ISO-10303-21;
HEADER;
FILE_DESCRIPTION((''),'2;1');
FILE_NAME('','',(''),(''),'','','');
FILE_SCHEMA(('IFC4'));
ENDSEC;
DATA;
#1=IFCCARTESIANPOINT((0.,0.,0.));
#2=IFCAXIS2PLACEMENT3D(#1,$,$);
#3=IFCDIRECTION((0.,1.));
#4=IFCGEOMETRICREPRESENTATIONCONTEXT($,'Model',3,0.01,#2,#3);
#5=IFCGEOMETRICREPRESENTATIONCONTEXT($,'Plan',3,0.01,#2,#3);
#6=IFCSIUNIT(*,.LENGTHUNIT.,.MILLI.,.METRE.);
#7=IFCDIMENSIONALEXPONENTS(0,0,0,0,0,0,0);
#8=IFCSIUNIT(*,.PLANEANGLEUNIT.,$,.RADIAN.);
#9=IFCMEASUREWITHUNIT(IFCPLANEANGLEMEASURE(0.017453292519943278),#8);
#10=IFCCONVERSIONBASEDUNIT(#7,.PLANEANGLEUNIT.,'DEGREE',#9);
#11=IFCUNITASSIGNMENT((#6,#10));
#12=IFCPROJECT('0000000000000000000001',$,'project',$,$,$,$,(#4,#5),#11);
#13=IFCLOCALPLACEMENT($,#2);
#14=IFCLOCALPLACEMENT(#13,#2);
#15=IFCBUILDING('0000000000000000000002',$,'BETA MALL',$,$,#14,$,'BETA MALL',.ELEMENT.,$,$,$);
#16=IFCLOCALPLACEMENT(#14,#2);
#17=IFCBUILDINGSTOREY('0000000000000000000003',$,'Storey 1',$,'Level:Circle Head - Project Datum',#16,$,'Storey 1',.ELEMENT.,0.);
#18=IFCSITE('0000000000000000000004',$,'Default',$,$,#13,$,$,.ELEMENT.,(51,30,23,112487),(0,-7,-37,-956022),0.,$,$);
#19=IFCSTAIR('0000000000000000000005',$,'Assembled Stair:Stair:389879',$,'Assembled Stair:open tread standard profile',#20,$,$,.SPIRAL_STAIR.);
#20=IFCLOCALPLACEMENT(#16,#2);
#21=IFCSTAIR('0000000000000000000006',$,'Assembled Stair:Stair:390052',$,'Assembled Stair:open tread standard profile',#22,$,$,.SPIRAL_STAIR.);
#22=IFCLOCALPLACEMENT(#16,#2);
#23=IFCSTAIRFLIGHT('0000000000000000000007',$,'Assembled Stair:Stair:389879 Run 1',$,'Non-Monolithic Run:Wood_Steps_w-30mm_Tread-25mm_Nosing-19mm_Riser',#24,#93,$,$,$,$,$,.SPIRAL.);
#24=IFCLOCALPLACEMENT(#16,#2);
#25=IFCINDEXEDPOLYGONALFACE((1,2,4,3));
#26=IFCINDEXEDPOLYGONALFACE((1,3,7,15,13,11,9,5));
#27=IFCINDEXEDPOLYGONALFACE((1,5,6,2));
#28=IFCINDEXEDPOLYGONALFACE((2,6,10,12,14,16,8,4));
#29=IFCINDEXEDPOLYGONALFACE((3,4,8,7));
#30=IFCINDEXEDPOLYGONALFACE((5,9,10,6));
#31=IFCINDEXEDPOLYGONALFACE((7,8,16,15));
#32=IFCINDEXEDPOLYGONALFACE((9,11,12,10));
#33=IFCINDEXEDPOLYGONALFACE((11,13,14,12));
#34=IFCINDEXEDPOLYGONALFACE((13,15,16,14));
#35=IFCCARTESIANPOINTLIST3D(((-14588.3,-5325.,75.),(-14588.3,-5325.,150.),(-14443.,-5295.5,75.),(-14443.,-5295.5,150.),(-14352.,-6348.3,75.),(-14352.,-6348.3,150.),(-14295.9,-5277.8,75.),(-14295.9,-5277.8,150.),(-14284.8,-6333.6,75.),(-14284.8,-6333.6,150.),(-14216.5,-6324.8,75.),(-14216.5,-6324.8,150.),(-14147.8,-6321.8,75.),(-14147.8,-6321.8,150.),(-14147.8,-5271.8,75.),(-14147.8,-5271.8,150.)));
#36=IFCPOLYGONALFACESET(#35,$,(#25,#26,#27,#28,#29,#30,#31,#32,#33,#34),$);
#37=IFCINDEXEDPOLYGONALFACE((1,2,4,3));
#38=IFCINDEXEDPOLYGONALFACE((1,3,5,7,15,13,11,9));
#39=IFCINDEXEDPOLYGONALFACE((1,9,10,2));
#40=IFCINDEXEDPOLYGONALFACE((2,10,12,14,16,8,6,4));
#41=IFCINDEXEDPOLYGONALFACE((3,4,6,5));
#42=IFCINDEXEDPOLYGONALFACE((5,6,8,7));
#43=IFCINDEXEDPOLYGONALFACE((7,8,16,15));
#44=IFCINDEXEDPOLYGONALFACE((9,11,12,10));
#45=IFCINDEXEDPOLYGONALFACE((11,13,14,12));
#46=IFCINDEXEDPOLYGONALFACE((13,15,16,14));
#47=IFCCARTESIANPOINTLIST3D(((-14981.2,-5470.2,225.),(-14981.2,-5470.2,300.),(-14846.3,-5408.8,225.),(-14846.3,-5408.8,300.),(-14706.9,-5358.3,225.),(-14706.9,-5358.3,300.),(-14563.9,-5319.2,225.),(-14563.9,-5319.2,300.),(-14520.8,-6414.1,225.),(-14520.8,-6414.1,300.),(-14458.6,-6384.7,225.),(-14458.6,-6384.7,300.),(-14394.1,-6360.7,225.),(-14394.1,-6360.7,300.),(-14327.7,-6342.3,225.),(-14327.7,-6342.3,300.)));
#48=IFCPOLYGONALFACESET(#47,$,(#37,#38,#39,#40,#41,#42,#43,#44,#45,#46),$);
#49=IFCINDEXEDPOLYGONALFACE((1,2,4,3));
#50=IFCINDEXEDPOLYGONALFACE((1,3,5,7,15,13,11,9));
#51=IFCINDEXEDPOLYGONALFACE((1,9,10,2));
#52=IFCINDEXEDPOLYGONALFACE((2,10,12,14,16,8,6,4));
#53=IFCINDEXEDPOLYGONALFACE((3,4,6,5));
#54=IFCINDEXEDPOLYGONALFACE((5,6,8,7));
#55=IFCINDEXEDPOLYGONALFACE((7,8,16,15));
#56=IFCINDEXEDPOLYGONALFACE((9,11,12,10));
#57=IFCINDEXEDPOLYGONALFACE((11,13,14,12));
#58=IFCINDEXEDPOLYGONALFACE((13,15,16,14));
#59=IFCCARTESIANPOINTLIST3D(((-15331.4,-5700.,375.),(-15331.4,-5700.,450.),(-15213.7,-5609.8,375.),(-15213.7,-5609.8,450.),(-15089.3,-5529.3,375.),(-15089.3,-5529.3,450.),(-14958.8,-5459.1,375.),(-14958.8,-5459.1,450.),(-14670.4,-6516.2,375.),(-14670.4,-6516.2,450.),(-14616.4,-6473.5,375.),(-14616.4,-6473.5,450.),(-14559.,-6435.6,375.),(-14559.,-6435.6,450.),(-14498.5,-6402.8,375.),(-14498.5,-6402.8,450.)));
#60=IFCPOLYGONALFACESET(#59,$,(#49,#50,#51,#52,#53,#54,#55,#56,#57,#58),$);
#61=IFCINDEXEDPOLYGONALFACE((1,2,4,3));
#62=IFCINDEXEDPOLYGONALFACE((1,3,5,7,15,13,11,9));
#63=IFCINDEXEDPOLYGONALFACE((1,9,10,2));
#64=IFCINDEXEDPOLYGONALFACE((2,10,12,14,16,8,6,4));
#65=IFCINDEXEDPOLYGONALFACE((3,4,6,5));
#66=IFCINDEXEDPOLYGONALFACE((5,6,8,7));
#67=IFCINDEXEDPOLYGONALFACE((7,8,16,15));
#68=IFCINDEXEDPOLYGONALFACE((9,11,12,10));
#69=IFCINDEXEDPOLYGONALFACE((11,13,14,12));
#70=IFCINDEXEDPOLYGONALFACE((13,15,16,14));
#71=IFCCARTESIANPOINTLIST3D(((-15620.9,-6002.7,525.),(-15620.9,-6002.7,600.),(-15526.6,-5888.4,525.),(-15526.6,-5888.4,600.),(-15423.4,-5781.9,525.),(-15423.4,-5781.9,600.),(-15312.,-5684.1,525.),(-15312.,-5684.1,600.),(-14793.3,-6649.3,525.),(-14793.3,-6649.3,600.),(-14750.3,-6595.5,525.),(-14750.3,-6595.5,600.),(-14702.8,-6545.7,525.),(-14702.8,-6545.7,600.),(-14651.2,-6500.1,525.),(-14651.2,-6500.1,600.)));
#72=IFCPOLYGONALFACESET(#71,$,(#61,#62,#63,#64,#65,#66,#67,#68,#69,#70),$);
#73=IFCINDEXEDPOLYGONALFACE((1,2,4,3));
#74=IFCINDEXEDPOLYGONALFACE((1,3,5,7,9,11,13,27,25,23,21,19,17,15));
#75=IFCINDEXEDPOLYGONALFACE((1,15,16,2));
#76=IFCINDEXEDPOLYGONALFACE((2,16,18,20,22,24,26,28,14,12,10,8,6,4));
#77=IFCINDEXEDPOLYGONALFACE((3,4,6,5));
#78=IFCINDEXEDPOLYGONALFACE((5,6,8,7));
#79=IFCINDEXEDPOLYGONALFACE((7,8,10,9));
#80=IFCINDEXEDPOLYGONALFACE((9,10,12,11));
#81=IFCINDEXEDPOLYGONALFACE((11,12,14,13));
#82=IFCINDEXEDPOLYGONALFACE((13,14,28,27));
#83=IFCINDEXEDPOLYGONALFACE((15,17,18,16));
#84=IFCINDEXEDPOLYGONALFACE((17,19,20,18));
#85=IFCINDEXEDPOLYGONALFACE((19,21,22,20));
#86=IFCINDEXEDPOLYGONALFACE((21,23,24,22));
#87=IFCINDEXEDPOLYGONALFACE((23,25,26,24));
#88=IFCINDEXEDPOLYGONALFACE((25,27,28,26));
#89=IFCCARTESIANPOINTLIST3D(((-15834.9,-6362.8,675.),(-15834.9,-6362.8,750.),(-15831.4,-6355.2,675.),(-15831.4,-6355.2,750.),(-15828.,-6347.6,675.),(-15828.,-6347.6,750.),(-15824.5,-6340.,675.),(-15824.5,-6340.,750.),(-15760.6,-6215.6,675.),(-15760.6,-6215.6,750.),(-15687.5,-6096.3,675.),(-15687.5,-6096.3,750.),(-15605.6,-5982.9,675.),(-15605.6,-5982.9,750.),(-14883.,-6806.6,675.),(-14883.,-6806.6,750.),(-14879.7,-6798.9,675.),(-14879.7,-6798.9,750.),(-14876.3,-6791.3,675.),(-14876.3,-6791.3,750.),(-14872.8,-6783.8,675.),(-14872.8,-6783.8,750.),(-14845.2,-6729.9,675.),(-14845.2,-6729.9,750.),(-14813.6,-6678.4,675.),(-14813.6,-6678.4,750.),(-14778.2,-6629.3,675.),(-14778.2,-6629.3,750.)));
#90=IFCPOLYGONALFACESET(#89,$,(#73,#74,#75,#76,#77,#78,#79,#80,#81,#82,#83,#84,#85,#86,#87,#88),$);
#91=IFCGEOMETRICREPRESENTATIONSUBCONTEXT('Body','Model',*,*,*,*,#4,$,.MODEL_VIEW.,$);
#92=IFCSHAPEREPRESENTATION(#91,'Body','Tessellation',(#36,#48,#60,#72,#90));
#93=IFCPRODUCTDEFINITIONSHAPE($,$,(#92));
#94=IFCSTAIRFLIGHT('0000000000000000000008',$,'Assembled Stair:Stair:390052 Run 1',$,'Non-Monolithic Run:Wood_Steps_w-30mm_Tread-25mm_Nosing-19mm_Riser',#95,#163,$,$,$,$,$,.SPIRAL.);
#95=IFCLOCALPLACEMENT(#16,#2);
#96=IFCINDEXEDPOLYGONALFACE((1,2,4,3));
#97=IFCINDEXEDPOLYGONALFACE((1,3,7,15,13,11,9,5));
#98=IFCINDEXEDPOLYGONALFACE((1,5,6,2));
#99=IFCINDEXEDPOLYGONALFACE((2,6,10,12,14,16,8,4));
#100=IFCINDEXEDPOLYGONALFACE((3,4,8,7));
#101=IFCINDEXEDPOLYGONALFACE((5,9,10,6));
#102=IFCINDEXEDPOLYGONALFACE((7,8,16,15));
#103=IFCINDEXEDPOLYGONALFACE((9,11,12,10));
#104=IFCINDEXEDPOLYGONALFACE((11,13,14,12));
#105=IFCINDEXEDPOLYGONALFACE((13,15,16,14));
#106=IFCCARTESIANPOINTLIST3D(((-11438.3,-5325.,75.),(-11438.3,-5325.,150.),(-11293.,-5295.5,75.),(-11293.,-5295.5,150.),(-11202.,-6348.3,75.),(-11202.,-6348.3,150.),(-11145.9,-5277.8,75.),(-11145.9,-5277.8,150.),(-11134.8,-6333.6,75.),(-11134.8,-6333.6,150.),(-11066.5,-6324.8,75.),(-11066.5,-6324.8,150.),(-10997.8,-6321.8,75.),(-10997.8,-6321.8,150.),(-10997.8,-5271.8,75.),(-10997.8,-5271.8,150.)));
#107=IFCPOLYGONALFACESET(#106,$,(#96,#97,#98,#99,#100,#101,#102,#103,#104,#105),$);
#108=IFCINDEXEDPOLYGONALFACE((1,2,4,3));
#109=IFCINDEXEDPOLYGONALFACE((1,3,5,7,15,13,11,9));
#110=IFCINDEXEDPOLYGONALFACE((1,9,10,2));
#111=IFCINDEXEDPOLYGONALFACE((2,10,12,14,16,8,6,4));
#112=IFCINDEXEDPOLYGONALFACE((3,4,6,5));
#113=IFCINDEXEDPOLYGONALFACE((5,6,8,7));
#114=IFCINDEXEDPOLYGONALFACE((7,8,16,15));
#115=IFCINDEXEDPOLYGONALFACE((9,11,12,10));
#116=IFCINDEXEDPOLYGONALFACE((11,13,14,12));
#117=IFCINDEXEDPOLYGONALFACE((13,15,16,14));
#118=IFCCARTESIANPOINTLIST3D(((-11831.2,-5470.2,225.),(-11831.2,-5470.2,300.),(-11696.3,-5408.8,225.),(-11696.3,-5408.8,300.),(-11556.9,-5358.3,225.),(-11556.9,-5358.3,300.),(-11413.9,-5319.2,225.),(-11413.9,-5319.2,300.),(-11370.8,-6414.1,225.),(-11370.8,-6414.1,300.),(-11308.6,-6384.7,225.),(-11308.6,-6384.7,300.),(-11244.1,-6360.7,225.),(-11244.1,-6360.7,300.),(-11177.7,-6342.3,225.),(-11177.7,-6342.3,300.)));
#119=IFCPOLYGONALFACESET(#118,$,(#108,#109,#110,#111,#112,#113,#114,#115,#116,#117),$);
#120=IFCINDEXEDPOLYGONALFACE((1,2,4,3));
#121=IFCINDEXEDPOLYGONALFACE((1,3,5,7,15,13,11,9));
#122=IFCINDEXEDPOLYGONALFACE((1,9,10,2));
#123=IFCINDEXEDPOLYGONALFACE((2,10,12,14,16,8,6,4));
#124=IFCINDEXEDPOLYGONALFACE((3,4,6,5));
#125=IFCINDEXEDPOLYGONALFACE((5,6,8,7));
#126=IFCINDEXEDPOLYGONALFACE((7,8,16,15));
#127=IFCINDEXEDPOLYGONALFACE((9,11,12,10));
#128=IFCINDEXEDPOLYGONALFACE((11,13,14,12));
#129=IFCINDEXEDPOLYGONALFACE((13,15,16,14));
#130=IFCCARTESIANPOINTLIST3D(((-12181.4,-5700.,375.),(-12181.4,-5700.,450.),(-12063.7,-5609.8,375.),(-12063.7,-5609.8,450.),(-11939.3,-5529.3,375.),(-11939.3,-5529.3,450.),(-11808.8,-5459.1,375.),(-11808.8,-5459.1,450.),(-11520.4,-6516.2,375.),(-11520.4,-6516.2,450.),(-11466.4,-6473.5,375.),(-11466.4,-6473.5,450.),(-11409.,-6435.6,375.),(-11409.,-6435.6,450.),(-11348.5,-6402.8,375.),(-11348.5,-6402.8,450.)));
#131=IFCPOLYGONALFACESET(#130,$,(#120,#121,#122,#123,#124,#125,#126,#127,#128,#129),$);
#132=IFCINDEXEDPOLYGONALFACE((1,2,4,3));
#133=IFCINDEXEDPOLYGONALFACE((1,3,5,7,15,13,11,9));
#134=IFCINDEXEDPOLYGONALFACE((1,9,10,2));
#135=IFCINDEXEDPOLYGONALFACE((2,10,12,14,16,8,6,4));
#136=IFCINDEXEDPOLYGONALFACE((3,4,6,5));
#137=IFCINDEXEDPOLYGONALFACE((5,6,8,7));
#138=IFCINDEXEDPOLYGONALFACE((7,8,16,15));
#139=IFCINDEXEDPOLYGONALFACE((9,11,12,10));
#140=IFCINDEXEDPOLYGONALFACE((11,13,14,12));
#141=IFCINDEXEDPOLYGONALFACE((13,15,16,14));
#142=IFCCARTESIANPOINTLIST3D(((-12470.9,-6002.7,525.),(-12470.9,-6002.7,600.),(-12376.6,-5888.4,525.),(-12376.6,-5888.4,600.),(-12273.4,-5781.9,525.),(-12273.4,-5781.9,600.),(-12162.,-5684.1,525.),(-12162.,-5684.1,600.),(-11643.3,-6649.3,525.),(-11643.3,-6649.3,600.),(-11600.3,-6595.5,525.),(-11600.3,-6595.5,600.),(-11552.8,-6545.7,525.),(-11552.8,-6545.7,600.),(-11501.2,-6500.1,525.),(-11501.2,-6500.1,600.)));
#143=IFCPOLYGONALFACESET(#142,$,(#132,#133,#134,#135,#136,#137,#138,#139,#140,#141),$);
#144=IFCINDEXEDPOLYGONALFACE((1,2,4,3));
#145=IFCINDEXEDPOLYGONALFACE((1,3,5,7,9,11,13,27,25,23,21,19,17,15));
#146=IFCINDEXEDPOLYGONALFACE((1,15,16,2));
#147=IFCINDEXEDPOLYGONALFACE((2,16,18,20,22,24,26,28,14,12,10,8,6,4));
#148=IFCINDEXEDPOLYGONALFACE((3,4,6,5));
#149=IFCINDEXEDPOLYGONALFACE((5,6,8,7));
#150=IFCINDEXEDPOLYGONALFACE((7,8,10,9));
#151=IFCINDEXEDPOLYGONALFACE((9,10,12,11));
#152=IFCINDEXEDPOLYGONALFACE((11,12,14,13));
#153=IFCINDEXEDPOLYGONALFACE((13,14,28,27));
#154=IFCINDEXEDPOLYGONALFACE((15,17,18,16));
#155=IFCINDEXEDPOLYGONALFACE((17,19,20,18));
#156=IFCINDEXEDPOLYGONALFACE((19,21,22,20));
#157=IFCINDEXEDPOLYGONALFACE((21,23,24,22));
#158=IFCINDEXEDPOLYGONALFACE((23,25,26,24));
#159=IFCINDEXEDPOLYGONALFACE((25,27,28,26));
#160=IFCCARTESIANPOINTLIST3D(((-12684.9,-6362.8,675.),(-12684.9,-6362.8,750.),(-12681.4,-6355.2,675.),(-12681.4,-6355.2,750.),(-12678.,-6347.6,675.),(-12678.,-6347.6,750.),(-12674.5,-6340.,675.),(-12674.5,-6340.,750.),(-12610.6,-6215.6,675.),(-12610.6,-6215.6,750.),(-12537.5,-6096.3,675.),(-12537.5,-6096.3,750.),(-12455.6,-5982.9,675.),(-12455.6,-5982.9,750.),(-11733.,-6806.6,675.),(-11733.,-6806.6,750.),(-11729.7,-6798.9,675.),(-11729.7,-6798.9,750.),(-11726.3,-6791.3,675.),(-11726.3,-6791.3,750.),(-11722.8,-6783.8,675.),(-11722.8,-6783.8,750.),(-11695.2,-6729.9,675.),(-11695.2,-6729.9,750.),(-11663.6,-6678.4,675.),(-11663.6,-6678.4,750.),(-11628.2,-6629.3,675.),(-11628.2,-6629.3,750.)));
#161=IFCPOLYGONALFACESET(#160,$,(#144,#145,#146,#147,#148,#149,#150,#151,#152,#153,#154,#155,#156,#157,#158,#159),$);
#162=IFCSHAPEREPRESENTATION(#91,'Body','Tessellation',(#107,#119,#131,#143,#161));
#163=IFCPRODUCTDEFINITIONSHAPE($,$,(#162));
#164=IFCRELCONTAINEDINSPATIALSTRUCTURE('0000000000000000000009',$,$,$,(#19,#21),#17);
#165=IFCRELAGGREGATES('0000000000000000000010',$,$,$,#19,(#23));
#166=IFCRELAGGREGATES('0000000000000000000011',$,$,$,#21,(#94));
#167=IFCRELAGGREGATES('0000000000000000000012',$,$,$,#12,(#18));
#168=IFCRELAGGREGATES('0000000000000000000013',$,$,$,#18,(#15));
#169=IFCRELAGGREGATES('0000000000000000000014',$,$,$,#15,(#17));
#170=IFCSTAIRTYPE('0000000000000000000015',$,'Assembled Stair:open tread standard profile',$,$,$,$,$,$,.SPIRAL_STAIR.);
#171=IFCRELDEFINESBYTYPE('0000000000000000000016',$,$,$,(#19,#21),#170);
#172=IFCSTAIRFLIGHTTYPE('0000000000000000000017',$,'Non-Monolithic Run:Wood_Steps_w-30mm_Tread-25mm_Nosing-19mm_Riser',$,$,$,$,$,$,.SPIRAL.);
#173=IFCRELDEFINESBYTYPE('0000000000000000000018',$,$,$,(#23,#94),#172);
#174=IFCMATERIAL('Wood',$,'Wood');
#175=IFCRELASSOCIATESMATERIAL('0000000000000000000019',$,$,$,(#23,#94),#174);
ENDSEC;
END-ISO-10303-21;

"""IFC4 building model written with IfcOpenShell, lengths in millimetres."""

from ifc_helpers import new_model, entity, si_unit, converted_unit, direction, frame, origin, place, context, subcontext, project, spatial, line, arc, indexed_curve, outline, extrude, material, type_object, element, aggregate, save


model = new_model("IFC4")

# Units and contexts
model_context = context("Model", 3, precision=0.01, world=origin(), true_north=direction((0.0, 1.0)))
plan_context = context("Plan", 3, precision=0.01, world=origin(), true_north=direction((0.0, 1.0)))
body_context = subcontext(model_context, "Body", "Model", "MODEL_VIEW")
ifc_project = project(units=[si_unit("LENGTHUNIT", "METRE", prefix="MILLI"), converted_unit("PLANEANGLEUNIT", "DEGREE", entity("IfcPlaneAngleMeasure", 0.017453292519943278), si_unit("PLANEANGLEUNIT", "RADIAN"), dimensions=[0, 0, 0, 0, 0, 0, 0])], contexts=[model_context, plan_context])

# Site, building, storey
site_placement = place(None, origin())
site = spatial("IfcSite", under=ifc_project, at=site_placement, Name="Default", CompositionType="ELEMENT", RefLatitude=(51, 30, 23, 112487), RefLongitude=(0, -7, -37, -956022), RefElevation=0.0)
building_placement = place(site_placement, origin())
building = spatial("IfcBuilding", under=site, at=building_placement, Name="BETA MALL", LongName="BETA MALL", CompositionType="ELEMENT")
storey_placement = place(building_placement, origin())
storey = spatial("IfcBuildingStorey", under=building, at=storey_placement, Name="Storey 1", ObjectType="Level:Circle Head - Project Datum", LongName="Storey 1", CompositionType="ELEMENT", Elevation=0.0)

# Stairs
stair_type_1 = type_object("IfcStairType", Name="Assembled Stair:open tread standard profile", PredefinedType="SPIRAL_STAIR")
ifc_material_1 = material(Name="Wood", Category="Wood")
stair_1_placement = place(storey_placement, origin())
stair_1 = element("IfcStair", 1, at=stair_1_placement, inside=storey, type_object=stair_type_1, Name="Assembled Stair:Stair:389879", ObjectType="Assembled Stair:open tread standard profile", PredefinedType="SPIRAL_STAIR")
stair_2_placement = place(storey_placement, origin())
stair_2 = element("IfcStair", 2, at=stair_2_placement, inside=storey, type_object=stair_type_1, Name="Assembled Stair:Stair:390052", ObjectType="Assembled Stair:open tread standard profile", PredefinedType="SPIRAL_STAIR")

# Stair flights
stair_flight_type_1 = type_object("IfcStairFlightType", Name="Non-Monolithic Run:Wood_Steps_w-30mm_Tread-25mm_Nosing-19mm_Riser", PredefinedType="SPIRAL")
stair_flight_1_placement = place(stair_1_placement, origin())
stair_flight_1 = element("IfcStairFlight", 3, at=stair_flight_1_placement, type_object=stair_flight_type_1, material=ifc_material_1, Name="Assembled Stair:Stair:389879 Run 1", ObjectType="Non-Monolithic Run:Wood_Steps_w-30mm_Tread-25mm_Nosing-19mm_Riser", PredefinedType="SPIRAL", context=body_context, shape_type="SweptSolid", body=[
    extrude(outline(indexed_curve([(-43.1, 531.6), (-279.3, -491.7), (-60.7, -531.6), (161.2, -544.9), (161.2, 505.1), (58.2, 511.7)], segments=[line(1, 2), arc(2, 3, 4), line(4, 5), arc(5, 6, 1)], self_intersect=False)), frame((-14308.9, -5816.7, 75.0), z_axis=(0.0, 0.0, -1.0), x_axis=(1.0, 0.0, 0.0)), (0.0, 0.0, -1.0), 75.0),
    extrude(outline(indexed_curve([(77.6, 527.6), (-382.8, -416.3), (-178.7, -504.3), (34.5, -567.2), (270.7, 455.9), (171.8, 485.5)], segments=[line(1, 2), arc(2, 3, 4), line(4, 5), arc(5, 6, 1)], self_intersect=False)), frame((-14598.4, -5886.5, 225.0), z_axis=(0.0, 0.0, -1.0), x_axis=(1.0, 0.0, 0.0)), (0.0, 0.0, -1.0), 75.0),
    extrude(outline(indexed_curve([(77.6, 527.6), (-382.8, -416.3), (-178.7, -504.3), (34.5, -567.2), (270.7, 455.9), (171.8, 485.5)], segments=[line(1, 2), arc(2, 3, 4), line(4, 5), arc(5, 6, 1)], self_intersect=False)), frame((-14864.8, -6019.5, 375.0), z_axis=(0.0, 0.0, -1.0), x_axis=(0.974368, 0.22496, 0.0)), (0.0, 0.0, -1.0), 75.0),
    extrude(outline(indexed_curve([(77.6, 527.6), (-382.8, -416.3), (-178.7, -504.3), (34.5, -567.2), (270.7, 455.9), (171.8, 485.5)], segments=[line(1, 2), arc(2, 3, 4), line(4, 5), arc(5, 6, 1)], self_intersect=False)), frame((-15094.4, -6209.0, 525.0), z_axis=(0.0, 0.0, -1.0), x_axis=(0.898786, 0.438387, 0.0)), (0.0, 0.0, -1.0), 75.0),
    extrude(outline(indexed_curve([(-124.0, 512.1), (-107.6, -538.0), (-95.1, -537.9), (-82.6, -537.8), (126.6, -522.6), (332.8, -483.9), (80.6, 535.4), (-8.6, 518.7), (-99.0, 512.1), (-111.5, 512.0)], segments=[line(1, 2), arc(2, 3, 4), arc(4, 5, 6), line(6, 7), arc(7, 8, 9), arc(9, 10, 1)], self_intersect=False)), frame((-15299.8, -6484.2, 675.0), z_axis=(0.0, 0.0, -1.0), x_axis=(0.408364, 0.912819, 0.0)), (0.0, 0.0, -1.0), 75.0),
])
aggregate(stair_1, [stair_flight_1])
stair_flight_2_placement = place(stair_2_placement, origin())
stair_flight_2 = element("IfcStairFlight", 4, at=stair_flight_2_placement, type_object=stair_flight_type_1, material=ifc_material_1, Name="Assembled Stair:Stair:390052 Run 1", ObjectType="Non-Monolithic Run:Wood_Steps_w-30mm_Tread-25mm_Nosing-19mm_Riser", PredefinedType="SPIRAL", context=body_context, shape_type="SweptSolid", body=[
    extrude(outline(indexed_curve([(-43.1, 531.6), (-279.3, -491.7), (-60.7, -531.6), (161.2, -544.9), (161.2, 505.1), (58.2, 511.7)], segments=[line(1, 2), arc(2, 3, 4), line(4, 5), arc(5, 6, 1)], self_intersect=False)), frame((-11158.9, -5816.7, 75.0), z_axis=(0.0, 0.0, -1.0), x_axis=(1.0, 0.0, 0.0)), (0.0, 0.0, -1.0), 75.0),
    extrude(outline(indexed_curve([(77.6, 527.6), (-382.8, -416.3), (-178.7, -504.3), (34.5, -567.2), (270.7, 455.9), (171.8, 485.5)], segments=[line(1, 2), arc(2, 3, 4), line(4, 5), arc(5, 6, 1)], self_intersect=False)), frame((-11448.4, -5886.5, 225.0), z_axis=(0.0, 0.0, -1.0), x_axis=(1.0, 0.0, 0.0)), (0.0, 0.0, -1.0), 75.0),
    extrude(outline(indexed_curve([(77.6, 527.6), (-382.8, -416.3), (-178.7, -504.3), (34.5, -567.2), (270.7, 455.9), (171.8, 485.5)], segments=[line(1, 2), arc(2, 3, 4), line(4, 5), arc(5, 6, 1)], self_intersect=False)), frame((-11714.8, -6019.5, 375.0), z_axis=(0.0, 0.0, -1.0), x_axis=(0.974368, 0.22496, 0.0)), (0.0, 0.0, -1.0), 75.0),
    extrude(outline(indexed_curve([(77.6, 527.6), (-382.8, -416.3), (-178.7, -504.3), (34.5, -567.2), (270.7, 455.9), (171.8, 485.5)], segments=[line(1, 2), arc(2, 3, 4), line(4, 5), arc(5, 6, 1)], self_intersect=False)), frame((-11944.4, -6209.0, 525.0), z_axis=(0.0, 0.0, -1.0), x_axis=(0.898786, 0.438387, 0.0)), (0.0, 0.0, -1.0), 75.0),
    extrude(outline(indexed_curve([(-124.0, 512.1), (-107.6, -538.0), (-95.1, -537.9), (-82.6, -537.8), (126.6, -522.6), (332.8, -483.9), (80.6, 535.4), (-8.6, 518.7), (-99.0, 512.1), (-111.5, 512.0)], segments=[line(1, 2), arc(2, 3, 4), arc(4, 5, 6), line(6, 7), arc(7, 8, 9), arc(9, 10, 1)], self_intersect=False)), frame((-12149.8, -6484.2, 675.0), z_axis=(0.0, 0.0, -1.0), x_axis=(0.408364, 0.912819, 0.0)), (0.0, 0.0, -1.0), 75.0),
])
aggregate(stair_2, [stair_flight_2])

save(model, "model.ifc")
